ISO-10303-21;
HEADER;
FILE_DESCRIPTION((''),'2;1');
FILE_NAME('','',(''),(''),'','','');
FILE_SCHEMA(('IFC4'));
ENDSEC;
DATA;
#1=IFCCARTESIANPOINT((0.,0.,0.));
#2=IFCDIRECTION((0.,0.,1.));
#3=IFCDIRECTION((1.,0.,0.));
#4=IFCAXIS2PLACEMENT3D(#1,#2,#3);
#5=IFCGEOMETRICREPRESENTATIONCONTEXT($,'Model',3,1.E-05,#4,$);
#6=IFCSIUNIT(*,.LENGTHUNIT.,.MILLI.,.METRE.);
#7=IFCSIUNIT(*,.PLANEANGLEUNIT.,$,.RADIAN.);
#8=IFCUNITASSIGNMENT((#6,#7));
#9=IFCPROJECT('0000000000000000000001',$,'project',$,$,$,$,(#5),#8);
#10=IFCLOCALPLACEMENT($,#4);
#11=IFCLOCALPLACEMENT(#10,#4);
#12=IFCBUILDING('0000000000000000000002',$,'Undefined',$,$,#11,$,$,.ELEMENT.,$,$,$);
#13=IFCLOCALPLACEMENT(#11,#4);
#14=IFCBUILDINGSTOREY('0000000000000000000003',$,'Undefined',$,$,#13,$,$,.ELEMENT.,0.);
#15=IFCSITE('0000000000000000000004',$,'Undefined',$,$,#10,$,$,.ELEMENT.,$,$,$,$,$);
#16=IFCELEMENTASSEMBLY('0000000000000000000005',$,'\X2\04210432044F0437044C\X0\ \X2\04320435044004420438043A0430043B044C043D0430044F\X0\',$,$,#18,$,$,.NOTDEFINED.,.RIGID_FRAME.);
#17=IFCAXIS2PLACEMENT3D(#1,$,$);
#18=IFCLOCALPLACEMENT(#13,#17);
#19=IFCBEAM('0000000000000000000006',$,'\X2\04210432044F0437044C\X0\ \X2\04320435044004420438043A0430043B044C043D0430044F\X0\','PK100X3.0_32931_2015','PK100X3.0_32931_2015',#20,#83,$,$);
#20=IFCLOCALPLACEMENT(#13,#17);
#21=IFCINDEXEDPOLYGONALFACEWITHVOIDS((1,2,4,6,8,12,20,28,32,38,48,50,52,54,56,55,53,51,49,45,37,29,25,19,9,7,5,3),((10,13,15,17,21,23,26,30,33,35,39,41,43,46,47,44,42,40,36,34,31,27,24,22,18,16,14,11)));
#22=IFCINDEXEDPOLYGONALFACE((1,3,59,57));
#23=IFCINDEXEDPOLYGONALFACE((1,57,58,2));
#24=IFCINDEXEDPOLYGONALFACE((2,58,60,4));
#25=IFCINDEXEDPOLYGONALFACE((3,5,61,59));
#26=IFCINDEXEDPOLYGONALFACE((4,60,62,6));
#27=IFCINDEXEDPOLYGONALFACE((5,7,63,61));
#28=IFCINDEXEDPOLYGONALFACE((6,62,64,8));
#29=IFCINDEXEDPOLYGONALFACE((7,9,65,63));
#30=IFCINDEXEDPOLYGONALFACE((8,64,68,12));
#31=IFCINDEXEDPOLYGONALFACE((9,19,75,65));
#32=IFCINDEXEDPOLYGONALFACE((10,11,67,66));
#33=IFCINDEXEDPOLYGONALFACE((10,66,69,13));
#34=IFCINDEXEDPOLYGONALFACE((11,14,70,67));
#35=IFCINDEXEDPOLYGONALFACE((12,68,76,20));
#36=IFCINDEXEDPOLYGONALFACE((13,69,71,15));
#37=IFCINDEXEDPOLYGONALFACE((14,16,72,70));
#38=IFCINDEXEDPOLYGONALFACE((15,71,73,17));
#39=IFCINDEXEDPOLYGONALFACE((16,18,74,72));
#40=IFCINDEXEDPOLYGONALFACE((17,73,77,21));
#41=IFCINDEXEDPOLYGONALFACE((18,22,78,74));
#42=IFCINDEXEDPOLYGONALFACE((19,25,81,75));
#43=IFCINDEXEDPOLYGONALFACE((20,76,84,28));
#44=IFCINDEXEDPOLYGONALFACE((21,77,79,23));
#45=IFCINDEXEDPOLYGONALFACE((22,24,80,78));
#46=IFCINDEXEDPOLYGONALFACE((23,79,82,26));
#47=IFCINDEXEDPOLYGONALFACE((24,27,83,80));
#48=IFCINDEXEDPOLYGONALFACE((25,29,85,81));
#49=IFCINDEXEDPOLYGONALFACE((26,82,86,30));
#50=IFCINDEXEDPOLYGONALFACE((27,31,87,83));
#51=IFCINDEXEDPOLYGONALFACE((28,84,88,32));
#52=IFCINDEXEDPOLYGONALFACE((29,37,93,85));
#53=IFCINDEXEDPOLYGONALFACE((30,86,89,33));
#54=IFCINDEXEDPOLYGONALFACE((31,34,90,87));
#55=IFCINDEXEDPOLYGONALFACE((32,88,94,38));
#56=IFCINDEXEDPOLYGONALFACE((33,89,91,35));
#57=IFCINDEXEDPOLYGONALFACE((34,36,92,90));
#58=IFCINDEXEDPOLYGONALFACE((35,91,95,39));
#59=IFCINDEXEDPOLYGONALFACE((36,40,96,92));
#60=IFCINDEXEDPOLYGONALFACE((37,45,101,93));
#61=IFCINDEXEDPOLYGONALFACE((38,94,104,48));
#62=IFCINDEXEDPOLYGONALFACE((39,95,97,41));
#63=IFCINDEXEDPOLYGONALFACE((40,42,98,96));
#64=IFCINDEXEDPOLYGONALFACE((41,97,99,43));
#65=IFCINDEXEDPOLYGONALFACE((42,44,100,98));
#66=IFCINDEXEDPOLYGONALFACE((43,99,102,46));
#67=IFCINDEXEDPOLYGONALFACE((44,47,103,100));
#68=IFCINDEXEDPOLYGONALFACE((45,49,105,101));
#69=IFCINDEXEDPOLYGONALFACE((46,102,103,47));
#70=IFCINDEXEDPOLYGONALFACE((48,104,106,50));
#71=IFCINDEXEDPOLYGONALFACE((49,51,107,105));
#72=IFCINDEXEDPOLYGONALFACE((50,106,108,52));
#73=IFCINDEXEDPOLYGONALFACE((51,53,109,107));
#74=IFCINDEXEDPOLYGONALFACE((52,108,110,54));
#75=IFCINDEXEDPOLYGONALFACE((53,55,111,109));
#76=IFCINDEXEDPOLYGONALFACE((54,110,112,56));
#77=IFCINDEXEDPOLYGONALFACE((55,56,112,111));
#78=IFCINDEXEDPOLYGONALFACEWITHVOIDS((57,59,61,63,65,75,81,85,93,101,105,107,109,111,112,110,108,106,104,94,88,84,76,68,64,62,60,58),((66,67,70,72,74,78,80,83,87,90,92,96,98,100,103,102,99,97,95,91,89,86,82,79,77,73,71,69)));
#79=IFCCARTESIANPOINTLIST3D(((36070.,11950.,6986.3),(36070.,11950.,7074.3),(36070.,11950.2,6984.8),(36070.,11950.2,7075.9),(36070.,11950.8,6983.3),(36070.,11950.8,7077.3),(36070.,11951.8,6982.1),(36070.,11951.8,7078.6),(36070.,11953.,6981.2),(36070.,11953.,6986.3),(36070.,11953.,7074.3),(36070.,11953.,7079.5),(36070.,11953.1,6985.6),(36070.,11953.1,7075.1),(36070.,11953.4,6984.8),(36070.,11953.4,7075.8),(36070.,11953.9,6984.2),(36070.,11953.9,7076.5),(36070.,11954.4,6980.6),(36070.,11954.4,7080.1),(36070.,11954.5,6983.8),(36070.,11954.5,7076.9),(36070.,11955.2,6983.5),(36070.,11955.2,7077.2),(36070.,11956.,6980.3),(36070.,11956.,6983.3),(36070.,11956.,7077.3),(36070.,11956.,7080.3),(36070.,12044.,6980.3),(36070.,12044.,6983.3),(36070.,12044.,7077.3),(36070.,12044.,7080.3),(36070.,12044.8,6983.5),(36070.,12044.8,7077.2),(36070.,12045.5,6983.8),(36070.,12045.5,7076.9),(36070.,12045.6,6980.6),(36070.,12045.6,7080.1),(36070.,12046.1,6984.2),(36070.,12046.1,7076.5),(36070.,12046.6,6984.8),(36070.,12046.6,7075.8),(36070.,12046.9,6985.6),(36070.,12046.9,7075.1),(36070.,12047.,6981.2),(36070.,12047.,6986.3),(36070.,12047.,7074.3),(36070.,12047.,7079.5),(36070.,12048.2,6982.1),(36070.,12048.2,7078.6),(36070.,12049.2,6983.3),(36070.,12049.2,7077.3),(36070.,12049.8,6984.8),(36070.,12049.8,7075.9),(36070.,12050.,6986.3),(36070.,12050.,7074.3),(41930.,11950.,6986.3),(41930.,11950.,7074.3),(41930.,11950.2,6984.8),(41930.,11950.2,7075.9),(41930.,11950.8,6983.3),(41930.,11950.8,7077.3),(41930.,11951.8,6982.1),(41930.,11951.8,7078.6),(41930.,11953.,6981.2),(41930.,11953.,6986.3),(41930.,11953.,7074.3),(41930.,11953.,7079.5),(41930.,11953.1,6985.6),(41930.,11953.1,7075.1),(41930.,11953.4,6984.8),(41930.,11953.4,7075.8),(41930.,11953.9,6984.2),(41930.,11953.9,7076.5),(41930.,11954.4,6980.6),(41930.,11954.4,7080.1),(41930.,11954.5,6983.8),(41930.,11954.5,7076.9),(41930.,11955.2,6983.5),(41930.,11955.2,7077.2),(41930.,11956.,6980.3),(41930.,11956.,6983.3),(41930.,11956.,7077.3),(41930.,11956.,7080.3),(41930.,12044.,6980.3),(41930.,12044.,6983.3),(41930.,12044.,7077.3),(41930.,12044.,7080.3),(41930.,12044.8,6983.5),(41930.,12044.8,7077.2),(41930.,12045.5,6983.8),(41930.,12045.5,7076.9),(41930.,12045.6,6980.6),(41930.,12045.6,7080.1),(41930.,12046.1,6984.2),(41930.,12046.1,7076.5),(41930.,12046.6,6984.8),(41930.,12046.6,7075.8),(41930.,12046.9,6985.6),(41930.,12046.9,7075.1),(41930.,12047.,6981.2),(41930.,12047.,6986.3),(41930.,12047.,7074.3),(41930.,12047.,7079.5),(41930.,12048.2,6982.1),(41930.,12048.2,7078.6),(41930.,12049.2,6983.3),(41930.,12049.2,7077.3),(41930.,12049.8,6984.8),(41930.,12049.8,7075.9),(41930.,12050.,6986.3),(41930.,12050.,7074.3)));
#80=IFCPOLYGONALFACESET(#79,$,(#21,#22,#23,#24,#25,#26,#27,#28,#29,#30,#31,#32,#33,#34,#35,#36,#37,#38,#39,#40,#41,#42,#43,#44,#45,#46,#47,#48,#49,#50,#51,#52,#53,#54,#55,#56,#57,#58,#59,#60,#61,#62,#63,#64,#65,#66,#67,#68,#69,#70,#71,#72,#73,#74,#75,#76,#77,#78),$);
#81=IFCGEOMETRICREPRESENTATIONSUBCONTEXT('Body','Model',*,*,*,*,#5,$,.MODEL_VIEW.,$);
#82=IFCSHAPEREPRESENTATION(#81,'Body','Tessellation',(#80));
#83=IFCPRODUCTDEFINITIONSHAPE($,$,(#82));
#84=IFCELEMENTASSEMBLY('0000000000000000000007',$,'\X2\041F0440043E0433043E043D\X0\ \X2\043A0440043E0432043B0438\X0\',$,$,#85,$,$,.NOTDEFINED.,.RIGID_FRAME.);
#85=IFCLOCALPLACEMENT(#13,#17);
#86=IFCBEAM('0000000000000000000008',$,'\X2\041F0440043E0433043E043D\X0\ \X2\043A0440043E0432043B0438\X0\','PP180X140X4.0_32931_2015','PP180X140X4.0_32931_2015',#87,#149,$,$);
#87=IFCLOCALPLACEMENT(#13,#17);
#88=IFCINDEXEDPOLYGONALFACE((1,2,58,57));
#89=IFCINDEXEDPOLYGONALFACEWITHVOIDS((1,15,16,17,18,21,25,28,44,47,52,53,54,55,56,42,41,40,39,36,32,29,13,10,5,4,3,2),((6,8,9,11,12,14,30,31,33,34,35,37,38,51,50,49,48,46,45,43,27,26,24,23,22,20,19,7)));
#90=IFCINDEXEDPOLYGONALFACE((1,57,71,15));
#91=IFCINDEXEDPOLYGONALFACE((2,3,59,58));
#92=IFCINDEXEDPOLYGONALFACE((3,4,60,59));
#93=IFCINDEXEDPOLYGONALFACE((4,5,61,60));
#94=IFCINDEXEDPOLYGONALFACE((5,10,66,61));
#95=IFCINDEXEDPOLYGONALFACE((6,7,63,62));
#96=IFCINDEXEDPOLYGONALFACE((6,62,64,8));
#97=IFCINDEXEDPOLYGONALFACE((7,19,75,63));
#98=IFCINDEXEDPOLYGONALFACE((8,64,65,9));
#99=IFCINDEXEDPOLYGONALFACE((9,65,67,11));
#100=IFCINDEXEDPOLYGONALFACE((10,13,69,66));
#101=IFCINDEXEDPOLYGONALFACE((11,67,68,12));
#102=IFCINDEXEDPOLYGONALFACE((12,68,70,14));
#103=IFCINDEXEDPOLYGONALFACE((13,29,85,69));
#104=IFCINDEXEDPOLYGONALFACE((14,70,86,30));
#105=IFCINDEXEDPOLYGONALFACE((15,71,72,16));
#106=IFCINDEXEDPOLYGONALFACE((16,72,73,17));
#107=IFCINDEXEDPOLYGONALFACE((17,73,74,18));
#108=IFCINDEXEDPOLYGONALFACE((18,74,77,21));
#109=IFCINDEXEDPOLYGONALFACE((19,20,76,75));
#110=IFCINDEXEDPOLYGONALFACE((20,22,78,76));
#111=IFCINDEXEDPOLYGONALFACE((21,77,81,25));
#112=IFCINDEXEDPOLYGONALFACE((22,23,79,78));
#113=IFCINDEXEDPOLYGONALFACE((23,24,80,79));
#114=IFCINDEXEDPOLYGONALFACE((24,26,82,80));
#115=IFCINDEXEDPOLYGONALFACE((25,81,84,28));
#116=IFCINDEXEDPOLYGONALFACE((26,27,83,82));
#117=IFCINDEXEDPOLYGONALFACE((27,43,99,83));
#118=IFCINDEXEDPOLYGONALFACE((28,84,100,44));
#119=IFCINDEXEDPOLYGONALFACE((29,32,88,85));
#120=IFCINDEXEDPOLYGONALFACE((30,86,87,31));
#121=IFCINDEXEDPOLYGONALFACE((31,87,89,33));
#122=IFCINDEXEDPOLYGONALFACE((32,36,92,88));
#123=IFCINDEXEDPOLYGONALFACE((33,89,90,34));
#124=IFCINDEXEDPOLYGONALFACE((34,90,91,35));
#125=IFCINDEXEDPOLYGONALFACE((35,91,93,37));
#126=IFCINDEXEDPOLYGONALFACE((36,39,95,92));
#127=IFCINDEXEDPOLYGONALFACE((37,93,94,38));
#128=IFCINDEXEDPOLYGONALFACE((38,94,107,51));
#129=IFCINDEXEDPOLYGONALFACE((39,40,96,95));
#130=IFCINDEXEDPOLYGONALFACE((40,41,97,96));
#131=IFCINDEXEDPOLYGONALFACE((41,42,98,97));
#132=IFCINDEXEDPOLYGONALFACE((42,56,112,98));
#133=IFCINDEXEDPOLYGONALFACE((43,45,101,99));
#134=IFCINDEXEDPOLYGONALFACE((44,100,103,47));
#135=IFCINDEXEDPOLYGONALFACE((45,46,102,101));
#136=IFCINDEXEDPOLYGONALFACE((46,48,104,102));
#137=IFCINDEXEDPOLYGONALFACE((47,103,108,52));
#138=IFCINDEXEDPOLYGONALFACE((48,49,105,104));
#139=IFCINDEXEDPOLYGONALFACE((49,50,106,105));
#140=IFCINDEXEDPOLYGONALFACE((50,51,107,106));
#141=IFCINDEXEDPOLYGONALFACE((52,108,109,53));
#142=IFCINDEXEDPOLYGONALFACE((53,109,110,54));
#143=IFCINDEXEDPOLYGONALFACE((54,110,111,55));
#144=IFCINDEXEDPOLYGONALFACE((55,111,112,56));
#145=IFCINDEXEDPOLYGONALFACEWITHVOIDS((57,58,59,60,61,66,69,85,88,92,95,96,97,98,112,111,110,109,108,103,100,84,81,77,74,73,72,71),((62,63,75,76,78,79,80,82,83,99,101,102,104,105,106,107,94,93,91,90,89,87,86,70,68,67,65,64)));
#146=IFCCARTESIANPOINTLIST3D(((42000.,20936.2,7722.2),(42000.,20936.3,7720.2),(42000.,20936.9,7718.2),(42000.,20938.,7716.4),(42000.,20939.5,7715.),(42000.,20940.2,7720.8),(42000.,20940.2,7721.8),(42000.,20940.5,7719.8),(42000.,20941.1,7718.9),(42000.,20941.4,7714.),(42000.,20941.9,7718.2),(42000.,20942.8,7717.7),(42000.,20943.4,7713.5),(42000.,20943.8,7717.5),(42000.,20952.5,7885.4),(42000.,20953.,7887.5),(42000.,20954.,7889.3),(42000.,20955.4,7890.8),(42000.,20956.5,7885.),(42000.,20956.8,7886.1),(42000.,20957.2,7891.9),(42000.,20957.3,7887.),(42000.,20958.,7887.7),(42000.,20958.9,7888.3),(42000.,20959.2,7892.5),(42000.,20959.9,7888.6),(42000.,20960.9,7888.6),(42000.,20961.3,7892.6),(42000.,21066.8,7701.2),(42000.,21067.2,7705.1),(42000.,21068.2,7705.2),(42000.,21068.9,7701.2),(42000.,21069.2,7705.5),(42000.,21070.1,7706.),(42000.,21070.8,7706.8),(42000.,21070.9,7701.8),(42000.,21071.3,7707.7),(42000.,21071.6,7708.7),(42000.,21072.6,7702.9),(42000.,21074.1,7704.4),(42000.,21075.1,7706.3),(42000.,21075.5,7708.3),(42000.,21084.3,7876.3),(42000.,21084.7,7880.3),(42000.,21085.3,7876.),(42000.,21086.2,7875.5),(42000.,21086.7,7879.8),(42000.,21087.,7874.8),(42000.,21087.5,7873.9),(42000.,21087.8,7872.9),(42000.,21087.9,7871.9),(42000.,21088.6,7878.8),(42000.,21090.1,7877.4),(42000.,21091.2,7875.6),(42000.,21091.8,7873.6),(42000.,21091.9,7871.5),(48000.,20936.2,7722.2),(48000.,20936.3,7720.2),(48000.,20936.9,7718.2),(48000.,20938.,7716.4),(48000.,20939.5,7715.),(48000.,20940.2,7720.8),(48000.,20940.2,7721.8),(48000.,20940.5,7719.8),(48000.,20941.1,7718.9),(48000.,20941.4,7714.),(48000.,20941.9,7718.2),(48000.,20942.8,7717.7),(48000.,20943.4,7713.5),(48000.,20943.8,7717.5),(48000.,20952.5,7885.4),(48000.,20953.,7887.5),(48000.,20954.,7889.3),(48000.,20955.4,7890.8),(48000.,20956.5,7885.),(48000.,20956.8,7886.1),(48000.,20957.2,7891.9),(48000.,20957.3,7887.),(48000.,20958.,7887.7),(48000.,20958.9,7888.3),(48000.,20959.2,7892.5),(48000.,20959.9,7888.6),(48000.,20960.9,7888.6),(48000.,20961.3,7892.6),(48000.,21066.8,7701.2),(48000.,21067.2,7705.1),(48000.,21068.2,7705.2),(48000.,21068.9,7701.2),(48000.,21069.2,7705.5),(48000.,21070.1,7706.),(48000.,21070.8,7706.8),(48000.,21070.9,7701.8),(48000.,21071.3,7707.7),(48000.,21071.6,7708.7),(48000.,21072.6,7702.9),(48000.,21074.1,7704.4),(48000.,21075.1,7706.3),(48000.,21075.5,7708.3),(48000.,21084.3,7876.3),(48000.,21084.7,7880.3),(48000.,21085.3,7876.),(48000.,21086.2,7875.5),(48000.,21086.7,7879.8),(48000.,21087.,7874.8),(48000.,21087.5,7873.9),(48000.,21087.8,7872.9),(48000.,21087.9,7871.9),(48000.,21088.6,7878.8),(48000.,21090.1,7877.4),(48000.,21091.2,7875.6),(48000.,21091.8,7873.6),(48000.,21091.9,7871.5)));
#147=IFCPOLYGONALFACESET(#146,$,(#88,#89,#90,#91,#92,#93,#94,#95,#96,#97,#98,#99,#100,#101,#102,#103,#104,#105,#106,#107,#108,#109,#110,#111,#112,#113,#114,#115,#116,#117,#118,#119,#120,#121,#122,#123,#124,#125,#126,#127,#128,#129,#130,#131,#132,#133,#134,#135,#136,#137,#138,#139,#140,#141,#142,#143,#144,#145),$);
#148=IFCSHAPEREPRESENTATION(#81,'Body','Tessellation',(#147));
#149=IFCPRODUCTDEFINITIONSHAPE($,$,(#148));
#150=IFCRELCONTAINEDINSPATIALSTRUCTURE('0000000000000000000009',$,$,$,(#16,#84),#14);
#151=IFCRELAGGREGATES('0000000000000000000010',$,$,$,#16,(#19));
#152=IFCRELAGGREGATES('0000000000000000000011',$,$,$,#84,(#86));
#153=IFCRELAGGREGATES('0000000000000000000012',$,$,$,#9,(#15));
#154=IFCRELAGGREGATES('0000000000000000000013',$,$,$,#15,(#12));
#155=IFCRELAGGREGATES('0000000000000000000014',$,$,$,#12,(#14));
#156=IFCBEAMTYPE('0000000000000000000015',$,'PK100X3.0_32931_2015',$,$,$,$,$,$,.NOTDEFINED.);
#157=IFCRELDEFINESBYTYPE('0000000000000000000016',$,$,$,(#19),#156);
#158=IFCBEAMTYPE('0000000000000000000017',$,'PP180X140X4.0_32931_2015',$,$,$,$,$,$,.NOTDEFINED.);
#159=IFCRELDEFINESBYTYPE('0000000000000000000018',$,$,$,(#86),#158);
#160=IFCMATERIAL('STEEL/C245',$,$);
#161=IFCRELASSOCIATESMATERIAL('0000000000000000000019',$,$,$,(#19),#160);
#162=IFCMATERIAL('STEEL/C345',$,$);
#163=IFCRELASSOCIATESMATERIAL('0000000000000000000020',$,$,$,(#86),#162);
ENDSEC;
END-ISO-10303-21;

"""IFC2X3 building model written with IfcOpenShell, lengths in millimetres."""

from ifc_helpers import new_model, si_unit, frame, origin_with_axes, origin_2d_with_axis, place, context, subcontext, project, spatial, hollow_rectangle, extrude, material, type_object, element, aggregate, save


model = new_model("IFC2X3")

# Units and contexts
model_context = context("Model", 3, precision=1e-05, world=origin_with_axes())
body_context = subcontext(model_context, "Body", "Model", "MODEL_VIEW")
ifc_project = project(units=[si_unit("LENGTHUNIT", "METRE", prefix="MILLI"), si_unit("PLANEANGLEUNIT", "RADIAN")], contexts=[model_context])

# Site, building, storey
site_placement = place(None, origin_with_axes())
site = spatial("IfcSite", under=ifc_project, at=site_placement, Name="Undefined", CompositionType="ELEMENT")
building_placement = place(site_placement, origin_with_axes())
building = spatial("IfcBuilding", under=site, at=building_placement, Name="Undefined", CompositionType="ELEMENT")
storey_placement = place(building_placement, origin_with_axes())
storey = spatial("IfcBuildingStorey", under=building, at=storey_placement, Name="Undefined", CompositionType="ELEMENT", Elevation=0.0)

# Element assemblies, beams
ifc_material_1 = material(Name="STEEL/C245")
beam_type_1 = type_object("IfcBeamType", Name="PK100X3.0_32931_2015", PredefinedType="NOTDEFINED")
assembly_1_placement = place(storey_placement, origin_with_axes())
assembly_1 = element("IfcElementAssembly", 1, at=assembly_1_placement, inside=storey, Name="Связь вертикальная", AssemblyPlace="NOTDEFINED", PredefinedType="RIGID_FRAME")
beam_1_placement = place(assembly_1_placement, frame((36070.0, 12000.0, 7030.3), z_axis=(0.0, 0.0, 1.0), x_axis=(1.0, 0.0, 0.0)))
beam_1 = element("IfcBeam", 2, at=beam_1_placement, type_object=beam_type_1, material=ifc_material_1, Name="Связь вертикальная", Description="PK100X3.0_32931_2015", ObjectType="PK100X3.0_32931_2015", context=body_context, shape_type="SweptSolid", body=[
    extrude(hollow_rectangle(XDim=100.0, YDim=100.0, WallThickness=3.0, InnerFilletRadius=3.0, OuterFilletRadius=6.0, at=origin_2d_with_axis()), frame((5860.0, 0.0, 0.0), z_axis=(-1.0, 0.0, 0.0), x_axis=(0.0, -1.0, 0.0)), (0.0, 0.0, 1.0), 5860.0),
])
aggregate(assembly_1, [beam_1])
assembly_2_placement = place(storey_placement, origin_with_axes())
assembly_2 = element("IfcElementAssembly", 3, at=assembly_2_placement, inside=storey, Name="Прогон кровли", AssemblyPlace="NOTDEFINED", PredefinedType="RIGID_FRAME")
ifc_material_2 = material(Name="STEEL/C345")
beam_type_2 = type_object("IfcBeamType", Name="PP180X140X4.0_32931_2015", PredefinedType="NOTDEFINED")
beam_2_placement = place(assembly_2_placement, frame((42000.0, 21014.0, 7796.9), z_axis=(0.0, 0.099504, 0.995037), x_axis=(1.0, 0.0, 0.0)))
beam_2 = element("IfcBeam", 4, at=beam_2_placement, type_object=beam_type_2, material=ifc_material_2, Name="Прогон кровли", Description="PP180X140X4.0_32931_2015", ObjectType="PP180X140X4.0_32931_2015", context=body_context, shape_type="SweptSolid", body=[
    extrude(hollow_rectangle(XDim=140.0, YDim=180.0, WallThickness=4.0, InnerFilletRadius=4.0, OuterFilletRadius=8.0, at=origin_2d_with_axis()), frame((6000.0, 0.0, 0.0), z_axis=(-1.0, 0.0, 0.0), x_axis=(0.0, -1.0, 0.0)), (0.0, 0.0, 1.0), 6000.0),
])
aggregate(assembly_2, [beam_2])

save(model, "model.ifc")
